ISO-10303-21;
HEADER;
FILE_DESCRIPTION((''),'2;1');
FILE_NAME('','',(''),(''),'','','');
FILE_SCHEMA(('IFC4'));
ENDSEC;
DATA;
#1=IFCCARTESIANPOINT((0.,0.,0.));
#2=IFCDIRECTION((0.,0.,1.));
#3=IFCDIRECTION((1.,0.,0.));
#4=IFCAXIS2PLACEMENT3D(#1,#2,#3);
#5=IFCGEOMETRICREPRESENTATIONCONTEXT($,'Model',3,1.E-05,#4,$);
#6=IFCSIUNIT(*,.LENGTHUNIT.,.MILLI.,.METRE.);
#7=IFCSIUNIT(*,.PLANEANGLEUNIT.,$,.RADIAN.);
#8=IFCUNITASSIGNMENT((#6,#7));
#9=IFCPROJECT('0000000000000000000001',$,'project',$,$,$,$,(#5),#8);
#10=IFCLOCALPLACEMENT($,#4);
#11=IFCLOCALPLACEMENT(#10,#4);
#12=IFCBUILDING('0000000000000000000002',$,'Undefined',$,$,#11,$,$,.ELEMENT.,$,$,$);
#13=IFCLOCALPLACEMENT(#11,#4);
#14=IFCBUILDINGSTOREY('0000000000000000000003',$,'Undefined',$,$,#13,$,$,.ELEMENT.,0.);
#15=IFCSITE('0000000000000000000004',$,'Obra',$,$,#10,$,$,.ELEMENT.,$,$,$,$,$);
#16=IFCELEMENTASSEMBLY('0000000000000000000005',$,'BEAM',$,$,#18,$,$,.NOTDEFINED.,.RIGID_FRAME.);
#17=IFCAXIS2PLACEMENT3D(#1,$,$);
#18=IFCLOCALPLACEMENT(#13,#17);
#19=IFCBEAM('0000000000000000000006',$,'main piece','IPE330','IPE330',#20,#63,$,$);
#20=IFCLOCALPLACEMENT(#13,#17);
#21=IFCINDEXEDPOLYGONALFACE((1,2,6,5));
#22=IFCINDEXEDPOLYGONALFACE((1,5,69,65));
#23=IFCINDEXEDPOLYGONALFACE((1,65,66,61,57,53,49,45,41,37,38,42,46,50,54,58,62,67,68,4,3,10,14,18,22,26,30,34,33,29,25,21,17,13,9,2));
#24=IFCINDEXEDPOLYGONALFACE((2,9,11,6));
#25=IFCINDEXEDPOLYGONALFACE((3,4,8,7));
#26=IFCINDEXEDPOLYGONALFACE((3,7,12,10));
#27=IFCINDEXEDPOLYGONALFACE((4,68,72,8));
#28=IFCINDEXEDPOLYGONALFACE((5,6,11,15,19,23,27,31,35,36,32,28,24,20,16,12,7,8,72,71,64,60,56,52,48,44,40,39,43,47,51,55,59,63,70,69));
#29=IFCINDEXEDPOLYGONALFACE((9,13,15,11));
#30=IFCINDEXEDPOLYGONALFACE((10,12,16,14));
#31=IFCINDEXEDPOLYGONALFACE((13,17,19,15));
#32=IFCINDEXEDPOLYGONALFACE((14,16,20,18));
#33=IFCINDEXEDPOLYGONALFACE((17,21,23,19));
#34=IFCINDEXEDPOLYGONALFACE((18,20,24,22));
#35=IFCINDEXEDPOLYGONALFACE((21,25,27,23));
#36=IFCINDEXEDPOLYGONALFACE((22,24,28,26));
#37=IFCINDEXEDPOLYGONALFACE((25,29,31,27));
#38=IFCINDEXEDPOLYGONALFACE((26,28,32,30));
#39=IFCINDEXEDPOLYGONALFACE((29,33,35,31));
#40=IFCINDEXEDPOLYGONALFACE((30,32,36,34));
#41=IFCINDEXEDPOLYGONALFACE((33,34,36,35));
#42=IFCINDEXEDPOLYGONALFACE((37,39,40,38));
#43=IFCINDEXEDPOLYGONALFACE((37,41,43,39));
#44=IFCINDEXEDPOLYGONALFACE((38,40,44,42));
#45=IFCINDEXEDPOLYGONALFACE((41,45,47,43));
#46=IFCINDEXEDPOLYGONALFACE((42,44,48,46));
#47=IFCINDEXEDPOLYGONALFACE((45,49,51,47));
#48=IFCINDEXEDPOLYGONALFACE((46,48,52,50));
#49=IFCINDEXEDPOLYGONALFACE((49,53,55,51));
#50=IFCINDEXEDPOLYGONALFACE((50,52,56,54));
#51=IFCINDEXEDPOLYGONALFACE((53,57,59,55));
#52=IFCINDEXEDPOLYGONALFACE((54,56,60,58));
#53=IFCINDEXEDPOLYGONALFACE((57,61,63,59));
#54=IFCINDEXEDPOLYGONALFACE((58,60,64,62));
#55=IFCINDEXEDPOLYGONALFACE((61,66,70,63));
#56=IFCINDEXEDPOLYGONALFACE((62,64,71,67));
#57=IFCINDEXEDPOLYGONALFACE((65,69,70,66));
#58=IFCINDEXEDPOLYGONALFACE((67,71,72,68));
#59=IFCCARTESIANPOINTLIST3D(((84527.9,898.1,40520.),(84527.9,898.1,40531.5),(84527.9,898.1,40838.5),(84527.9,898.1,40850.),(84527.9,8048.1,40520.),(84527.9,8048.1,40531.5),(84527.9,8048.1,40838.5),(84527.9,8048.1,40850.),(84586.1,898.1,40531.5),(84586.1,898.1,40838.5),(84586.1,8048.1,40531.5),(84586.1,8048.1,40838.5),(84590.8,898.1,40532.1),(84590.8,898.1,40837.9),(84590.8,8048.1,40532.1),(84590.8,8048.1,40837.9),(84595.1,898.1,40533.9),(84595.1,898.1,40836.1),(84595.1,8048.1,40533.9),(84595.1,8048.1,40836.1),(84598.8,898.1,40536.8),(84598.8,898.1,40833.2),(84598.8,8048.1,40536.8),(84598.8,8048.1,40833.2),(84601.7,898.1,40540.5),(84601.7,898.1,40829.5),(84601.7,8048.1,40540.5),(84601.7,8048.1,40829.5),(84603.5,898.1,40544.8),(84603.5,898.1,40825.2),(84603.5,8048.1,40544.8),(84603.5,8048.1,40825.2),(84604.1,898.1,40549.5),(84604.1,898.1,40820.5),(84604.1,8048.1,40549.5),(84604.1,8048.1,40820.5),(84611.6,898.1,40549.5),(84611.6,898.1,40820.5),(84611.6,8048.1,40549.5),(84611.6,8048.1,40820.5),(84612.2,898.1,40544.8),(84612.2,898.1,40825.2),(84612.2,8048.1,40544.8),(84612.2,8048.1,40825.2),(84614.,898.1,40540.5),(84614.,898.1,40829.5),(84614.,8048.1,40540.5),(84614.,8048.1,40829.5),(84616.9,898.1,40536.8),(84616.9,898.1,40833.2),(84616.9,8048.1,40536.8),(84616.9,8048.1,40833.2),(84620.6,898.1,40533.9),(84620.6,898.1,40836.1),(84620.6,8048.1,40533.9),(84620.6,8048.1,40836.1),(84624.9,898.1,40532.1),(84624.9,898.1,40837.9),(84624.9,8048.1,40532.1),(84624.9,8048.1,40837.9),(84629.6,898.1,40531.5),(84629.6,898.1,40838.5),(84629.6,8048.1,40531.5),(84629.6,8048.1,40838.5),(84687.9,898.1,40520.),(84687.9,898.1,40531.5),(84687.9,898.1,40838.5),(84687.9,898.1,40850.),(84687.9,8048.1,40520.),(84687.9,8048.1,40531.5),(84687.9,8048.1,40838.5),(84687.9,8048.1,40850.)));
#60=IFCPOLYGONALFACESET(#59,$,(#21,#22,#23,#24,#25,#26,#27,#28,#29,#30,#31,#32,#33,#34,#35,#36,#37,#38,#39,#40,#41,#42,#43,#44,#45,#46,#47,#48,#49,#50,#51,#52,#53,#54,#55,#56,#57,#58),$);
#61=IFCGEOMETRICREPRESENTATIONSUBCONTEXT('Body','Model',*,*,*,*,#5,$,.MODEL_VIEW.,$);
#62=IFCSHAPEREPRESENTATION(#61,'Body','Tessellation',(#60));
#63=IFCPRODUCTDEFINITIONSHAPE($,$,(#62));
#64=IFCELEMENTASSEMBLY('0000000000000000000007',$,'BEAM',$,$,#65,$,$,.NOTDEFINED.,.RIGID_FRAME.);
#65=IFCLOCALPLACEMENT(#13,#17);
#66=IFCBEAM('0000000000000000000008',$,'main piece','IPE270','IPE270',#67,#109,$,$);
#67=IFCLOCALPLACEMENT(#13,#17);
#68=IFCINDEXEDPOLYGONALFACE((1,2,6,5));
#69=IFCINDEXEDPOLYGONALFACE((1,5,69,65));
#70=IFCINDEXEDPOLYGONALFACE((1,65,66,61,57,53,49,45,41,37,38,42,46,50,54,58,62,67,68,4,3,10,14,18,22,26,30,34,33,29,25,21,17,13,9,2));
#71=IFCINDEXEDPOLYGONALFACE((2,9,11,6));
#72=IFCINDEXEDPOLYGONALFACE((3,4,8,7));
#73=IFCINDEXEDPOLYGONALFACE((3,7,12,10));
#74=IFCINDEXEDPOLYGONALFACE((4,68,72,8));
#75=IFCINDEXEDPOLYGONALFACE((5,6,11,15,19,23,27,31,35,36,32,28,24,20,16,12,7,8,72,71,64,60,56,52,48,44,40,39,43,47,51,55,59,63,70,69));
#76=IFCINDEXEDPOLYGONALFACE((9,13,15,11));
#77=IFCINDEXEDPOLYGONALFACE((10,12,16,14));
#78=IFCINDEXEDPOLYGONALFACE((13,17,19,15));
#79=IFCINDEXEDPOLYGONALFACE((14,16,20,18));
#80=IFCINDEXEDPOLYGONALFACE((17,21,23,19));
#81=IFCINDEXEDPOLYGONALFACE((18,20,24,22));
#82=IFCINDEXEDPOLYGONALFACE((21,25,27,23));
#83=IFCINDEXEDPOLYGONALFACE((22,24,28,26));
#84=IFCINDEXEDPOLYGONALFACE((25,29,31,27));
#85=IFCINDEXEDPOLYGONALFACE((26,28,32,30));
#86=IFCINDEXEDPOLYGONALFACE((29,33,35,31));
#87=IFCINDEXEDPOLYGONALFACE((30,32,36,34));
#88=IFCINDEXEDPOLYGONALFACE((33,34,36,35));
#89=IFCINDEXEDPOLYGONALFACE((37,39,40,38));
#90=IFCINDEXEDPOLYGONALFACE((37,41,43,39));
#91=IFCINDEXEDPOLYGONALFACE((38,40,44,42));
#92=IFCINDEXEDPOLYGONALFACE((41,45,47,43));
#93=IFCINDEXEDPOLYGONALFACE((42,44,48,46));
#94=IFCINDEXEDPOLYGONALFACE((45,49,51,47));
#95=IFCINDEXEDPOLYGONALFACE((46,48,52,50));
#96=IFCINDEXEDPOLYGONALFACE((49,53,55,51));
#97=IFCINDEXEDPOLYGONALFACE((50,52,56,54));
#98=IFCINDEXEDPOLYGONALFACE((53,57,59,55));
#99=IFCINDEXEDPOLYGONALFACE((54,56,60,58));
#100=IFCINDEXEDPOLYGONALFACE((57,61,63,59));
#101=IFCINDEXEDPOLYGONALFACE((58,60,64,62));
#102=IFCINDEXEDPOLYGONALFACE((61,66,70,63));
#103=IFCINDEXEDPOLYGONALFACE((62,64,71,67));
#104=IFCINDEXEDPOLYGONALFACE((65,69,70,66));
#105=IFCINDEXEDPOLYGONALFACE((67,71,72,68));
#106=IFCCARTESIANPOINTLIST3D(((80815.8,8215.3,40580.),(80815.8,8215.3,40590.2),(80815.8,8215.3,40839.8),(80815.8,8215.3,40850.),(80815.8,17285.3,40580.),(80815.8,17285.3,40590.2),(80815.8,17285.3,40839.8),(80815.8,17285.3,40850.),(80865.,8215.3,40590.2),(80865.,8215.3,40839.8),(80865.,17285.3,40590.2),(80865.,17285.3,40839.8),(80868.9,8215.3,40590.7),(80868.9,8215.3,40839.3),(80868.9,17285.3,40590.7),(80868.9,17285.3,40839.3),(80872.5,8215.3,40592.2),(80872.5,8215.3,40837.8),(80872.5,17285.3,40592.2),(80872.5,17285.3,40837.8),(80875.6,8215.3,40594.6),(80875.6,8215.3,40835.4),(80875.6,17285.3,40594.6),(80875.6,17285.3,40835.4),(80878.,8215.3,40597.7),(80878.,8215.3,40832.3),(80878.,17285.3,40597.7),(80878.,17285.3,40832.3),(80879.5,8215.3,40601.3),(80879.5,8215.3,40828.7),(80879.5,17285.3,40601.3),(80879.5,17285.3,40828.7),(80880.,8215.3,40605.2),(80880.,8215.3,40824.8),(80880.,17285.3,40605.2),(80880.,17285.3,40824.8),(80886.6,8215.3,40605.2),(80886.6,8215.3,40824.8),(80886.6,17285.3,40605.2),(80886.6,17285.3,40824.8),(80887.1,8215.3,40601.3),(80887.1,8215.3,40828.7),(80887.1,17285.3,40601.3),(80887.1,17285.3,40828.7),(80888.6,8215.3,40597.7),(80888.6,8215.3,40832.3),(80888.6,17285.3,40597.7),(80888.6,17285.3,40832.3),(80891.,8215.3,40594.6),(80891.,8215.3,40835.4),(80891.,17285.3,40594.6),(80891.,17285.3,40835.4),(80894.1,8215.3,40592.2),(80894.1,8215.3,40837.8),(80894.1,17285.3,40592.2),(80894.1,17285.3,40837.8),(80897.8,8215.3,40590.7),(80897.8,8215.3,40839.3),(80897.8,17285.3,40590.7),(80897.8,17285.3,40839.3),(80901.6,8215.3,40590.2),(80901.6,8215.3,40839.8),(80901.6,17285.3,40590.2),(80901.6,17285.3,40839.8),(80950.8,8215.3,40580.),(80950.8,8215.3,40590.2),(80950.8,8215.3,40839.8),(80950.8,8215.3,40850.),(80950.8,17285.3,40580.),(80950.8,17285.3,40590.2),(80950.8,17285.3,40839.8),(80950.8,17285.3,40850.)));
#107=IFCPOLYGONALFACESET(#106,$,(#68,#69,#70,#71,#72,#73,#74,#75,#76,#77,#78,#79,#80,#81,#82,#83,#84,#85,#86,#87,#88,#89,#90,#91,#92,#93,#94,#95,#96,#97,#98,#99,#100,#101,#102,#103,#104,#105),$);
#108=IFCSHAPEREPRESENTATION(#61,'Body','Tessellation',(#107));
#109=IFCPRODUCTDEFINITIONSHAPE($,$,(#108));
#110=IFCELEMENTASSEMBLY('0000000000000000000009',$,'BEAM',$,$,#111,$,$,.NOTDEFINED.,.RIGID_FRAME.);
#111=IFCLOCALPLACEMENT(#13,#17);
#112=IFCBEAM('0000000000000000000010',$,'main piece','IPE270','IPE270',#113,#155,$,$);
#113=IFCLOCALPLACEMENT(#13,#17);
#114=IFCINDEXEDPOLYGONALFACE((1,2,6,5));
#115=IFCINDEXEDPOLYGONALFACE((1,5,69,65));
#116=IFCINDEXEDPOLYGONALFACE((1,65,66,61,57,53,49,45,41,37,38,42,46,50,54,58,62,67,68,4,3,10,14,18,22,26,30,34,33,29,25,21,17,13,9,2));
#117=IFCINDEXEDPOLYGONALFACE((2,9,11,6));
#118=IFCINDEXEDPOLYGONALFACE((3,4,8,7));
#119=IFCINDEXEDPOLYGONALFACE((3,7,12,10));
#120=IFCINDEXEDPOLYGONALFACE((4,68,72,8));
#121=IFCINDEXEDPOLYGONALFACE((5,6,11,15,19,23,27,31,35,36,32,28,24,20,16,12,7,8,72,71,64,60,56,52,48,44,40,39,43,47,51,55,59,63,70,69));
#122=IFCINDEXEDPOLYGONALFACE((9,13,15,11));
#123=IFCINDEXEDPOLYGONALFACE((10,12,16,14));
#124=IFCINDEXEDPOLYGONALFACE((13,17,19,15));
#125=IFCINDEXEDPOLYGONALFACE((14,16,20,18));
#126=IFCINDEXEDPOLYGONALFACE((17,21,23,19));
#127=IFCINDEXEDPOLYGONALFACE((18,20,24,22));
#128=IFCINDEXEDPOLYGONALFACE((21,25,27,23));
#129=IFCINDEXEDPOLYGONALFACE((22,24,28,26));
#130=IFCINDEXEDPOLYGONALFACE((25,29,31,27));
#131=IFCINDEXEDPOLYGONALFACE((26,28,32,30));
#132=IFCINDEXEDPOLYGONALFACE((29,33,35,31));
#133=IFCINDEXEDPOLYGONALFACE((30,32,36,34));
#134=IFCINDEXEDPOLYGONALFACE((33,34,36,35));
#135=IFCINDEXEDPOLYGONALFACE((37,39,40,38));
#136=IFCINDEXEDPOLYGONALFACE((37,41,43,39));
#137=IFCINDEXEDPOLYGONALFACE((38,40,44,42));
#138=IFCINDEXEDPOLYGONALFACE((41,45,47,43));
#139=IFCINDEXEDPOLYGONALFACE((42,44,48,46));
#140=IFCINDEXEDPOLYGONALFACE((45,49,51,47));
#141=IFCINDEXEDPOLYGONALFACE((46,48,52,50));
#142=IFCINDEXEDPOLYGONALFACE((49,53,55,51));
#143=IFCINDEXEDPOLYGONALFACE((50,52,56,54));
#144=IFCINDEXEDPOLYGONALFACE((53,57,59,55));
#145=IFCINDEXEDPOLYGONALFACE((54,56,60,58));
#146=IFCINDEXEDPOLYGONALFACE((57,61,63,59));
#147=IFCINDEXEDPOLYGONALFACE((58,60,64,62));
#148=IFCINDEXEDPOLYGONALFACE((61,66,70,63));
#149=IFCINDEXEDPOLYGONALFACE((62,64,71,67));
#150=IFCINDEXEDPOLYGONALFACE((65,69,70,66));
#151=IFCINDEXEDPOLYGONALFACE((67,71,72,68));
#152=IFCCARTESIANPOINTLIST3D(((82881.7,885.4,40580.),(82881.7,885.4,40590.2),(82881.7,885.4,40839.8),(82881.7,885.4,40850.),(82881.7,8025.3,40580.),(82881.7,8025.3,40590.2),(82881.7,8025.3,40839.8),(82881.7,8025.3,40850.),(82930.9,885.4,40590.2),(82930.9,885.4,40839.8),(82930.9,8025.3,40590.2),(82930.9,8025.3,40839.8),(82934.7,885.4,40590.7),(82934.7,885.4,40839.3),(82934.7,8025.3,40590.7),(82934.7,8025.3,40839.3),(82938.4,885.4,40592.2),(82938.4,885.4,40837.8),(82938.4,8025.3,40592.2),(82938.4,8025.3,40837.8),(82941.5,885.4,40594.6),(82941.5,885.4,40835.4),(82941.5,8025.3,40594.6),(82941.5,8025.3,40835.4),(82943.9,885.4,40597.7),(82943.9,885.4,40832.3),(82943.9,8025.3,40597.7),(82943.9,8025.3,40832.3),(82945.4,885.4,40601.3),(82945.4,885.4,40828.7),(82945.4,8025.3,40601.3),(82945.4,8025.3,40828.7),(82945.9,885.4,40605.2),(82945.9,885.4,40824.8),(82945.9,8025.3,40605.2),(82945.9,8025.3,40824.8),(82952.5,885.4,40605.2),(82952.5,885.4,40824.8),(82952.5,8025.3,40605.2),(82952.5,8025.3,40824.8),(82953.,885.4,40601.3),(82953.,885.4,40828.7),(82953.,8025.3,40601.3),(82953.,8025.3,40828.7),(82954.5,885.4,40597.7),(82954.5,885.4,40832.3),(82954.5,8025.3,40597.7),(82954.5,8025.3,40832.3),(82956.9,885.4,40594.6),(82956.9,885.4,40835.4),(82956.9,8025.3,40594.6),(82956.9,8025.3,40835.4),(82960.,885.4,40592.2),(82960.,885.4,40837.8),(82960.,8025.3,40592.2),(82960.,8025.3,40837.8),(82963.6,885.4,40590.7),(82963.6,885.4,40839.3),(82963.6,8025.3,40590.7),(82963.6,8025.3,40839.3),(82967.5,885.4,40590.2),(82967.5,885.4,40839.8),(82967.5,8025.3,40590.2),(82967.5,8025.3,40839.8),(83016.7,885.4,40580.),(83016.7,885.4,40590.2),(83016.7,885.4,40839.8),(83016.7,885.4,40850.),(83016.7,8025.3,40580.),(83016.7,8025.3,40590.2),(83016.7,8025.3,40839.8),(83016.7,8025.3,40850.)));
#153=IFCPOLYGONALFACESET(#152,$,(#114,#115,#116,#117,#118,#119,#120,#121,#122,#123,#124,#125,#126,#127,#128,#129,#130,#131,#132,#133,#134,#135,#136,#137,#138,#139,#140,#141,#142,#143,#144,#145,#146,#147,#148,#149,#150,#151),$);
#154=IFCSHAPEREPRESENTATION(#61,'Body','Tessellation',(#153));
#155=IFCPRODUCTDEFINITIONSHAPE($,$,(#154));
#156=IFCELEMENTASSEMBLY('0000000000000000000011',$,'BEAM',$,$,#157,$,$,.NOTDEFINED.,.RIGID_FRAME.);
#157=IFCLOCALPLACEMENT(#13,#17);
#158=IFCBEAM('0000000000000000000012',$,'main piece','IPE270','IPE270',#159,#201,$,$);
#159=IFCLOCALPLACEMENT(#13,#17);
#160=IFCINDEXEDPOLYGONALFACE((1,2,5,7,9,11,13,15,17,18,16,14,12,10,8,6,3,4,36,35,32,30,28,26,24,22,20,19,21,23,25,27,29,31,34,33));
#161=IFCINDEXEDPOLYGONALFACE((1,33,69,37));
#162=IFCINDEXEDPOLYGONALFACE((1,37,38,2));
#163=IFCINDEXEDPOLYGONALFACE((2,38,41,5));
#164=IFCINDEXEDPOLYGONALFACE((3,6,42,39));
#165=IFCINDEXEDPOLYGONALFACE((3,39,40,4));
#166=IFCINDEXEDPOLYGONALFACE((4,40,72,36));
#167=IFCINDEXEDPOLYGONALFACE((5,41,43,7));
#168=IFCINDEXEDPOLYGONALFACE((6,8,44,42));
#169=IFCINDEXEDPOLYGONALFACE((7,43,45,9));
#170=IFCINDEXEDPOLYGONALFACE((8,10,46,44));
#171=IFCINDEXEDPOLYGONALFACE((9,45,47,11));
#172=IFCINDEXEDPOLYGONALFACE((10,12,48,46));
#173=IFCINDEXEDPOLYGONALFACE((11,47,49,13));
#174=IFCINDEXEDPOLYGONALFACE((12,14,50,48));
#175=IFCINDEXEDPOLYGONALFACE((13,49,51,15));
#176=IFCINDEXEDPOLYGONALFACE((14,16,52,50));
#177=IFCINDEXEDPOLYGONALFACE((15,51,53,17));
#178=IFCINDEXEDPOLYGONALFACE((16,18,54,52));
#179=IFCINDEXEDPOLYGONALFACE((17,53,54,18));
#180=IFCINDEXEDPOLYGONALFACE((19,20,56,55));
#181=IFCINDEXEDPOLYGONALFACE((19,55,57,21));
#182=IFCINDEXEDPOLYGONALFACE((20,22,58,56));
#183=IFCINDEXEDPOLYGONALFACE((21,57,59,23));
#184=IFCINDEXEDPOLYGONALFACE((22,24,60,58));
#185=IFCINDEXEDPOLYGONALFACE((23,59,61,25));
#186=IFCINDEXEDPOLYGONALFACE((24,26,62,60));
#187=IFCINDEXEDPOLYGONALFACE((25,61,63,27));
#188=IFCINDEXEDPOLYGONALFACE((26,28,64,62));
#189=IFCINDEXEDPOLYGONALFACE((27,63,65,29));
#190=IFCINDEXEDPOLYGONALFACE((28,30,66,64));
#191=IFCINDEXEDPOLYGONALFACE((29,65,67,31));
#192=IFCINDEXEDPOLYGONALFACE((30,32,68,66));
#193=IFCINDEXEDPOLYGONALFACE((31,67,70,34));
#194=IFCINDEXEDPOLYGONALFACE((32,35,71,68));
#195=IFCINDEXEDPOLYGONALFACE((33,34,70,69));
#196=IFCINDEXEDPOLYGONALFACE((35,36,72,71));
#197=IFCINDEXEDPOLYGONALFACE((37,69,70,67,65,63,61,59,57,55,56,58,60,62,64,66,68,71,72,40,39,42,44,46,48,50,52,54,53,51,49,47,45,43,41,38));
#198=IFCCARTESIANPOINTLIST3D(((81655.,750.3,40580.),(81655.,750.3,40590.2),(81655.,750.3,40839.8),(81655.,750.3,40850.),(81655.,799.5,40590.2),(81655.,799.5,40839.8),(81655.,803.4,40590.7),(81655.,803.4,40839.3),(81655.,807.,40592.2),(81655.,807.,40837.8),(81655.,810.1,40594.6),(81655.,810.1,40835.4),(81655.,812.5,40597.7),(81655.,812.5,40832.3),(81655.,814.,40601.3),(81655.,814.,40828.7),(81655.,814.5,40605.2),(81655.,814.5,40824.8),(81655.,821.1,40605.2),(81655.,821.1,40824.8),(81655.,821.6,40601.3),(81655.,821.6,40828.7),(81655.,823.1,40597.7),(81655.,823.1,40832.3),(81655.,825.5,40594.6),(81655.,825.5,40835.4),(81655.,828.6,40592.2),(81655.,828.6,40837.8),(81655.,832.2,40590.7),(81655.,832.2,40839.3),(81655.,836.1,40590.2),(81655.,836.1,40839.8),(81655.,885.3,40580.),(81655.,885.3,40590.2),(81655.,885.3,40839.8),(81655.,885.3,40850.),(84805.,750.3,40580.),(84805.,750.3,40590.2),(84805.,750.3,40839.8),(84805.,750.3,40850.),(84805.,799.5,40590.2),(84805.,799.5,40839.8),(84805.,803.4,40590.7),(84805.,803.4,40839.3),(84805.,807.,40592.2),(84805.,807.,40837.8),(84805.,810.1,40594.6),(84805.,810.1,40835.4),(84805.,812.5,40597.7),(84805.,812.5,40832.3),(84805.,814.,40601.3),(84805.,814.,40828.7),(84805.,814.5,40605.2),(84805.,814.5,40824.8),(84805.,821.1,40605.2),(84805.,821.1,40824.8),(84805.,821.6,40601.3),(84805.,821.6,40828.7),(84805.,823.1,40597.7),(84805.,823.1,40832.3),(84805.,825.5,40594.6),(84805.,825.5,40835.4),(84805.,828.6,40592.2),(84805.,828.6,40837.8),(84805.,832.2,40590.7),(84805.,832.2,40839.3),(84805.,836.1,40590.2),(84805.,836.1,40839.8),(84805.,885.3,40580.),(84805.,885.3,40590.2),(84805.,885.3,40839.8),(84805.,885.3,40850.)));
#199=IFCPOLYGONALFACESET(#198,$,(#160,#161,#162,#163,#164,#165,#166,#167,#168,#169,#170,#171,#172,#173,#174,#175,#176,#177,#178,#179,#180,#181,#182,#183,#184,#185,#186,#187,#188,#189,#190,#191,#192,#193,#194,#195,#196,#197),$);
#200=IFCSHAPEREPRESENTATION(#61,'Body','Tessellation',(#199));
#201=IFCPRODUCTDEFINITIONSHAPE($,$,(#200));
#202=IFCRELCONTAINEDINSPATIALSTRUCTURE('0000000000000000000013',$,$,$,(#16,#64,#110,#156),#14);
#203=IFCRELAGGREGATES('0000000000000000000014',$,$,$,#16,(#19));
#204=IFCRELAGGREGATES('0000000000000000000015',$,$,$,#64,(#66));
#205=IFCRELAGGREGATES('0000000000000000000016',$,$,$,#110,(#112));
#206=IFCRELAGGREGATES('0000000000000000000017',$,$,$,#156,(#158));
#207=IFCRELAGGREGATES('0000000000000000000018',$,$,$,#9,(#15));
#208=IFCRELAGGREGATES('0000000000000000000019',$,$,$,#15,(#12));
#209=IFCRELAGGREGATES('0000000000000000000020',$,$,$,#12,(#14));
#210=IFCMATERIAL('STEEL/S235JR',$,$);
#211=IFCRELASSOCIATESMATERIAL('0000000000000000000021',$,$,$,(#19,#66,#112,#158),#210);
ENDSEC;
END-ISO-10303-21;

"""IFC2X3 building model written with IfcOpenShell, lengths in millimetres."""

from ifc_helpers import new_model, si_unit, frame, origin_with_axes, origin_2d_with_axis, place, context, subcontext, project, spatial, i_section, extrude, material, element, aggregate, save


model = new_model("IFC2X3")

# Units and contexts
model_context = context("Model", 3, precision=1e-05, world=origin_with_axes())
body_context = subcontext(model_context, "Body", "Model", "MODEL_VIEW")
ifc_project = project(units=[si_unit("LENGTHUNIT", "METRE", prefix="MILLI"), si_unit("PLANEANGLEUNIT", "RADIAN")], contexts=[model_context])

# Site, building, storey
site_placement = place(None, origin_with_axes())
site = spatial("IfcSite", under=ifc_project, at=site_placement, Name="Obra", CompositionType="ELEMENT")
building_placement = place(site_placement, origin_with_axes())
building = spatial("IfcBuilding", under=site, at=building_placement, Name="Undefined", CompositionType="ELEMENT")
storey_placement = place(building_placement, origin_with_axes())
storey = spatial("IfcBuildingStorey", under=building, at=storey_placement, Name="Undefined", CompositionType="ELEMENT", Elevation=0.0)

# Shared definitions
ifc_material_1 = material(Name="STEEL/S235JR")

# Element assemblies, beams
assembly_1_placement = place(storey_placement, origin_with_axes())
assembly_1 = element("IfcElementAssembly", 1, at=assembly_1_placement, inside=storey, Name="BEAM", AssemblyPlace="NOTDEFINED", PredefinedType="RIGID_FRAME")
beam_1_placement = place(assembly_1_placement, frame((84607.9, 898.1, 40685.0), z_axis=(0.0, 0.0, 1.0), x_axis=(0.0, 1.0, 0.0)))
beam_1 = element("IfcBeam", 2, at=beam_1_placement, material=ifc_material_1, Name="main piece", Description="IPE330", ObjectType="IPE330", context=body_context, shape_type="SweptSolid", body=[
    extrude(i_section(OverallWidth=160.0, OverallDepth=330.0, WebThickness=7.5, FlangeThickness=11.5, FilletRadius=18.0, at=origin_2d_with_axis()), frame((7150.0, 0.0, 0.0), z_axis=(-1.0, 0.0, 0.0), x_axis=(0.0, -1.0, 0.0)), (0.0, 0.0, 1.0), 7150.0),
])
aggregate(assembly_1, [beam_1])
assembly_2_placement = place(storey_placement, origin_with_axes())
assembly_2 = element("IfcElementAssembly", 3, at=assembly_2_placement, inside=storey, Name="BEAM", AssemblyPlace="NOTDEFINED", PredefinedType="RIGID_FRAME")
beam_2_placement = place(assembly_2_placement, frame((80883.3, 8215.3, 40715.0), z_axis=(0.0, 0.0, 1.0), x_axis=(0.0, 1.0, 0.0)))
beam_2 = element("IfcBeam", 4, at=beam_2_placement, material=ifc_material_1, Name="main piece", Description="IPE270", ObjectType="IPE270", context=body_context, shape_type="SweptSolid", body=[
    extrude(i_section(OverallWidth=135.0, OverallDepth=270.0, WebThickness=6.6, FlangeThickness=10.2, FilletRadius=15.0, at=origin_2d_with_axis()), frame((9070.0, 0.0, 0.0), z_axis=(-1.0, 0.0, 0.0), x_axis=(0.0, -1.0, 0.0)), (0.0, 0.0, 1.0), 9070.0),
])
aggregate(assembly_2, [beam_2])
assembly_3_placement = place(storey_placement, origin_with_axes())
assembly_3 = element("IfcElementAssembly", 5, at=assembly_3_placement, inside=storey, Name="BEAM", AssemblyPlace="NOTDEFINED", PredefinedType="RIGID_FRAME")
beam_3_placement = place(assembly_3_placement, frame((82949.2, 885.4, 40715.0), z_axis=(0.0, 0.0, 1.0), x_axis=(0.0, 1.0, 0.0)))
beam_3 = element("IfcBeam", 6, at=beam_3_placement, material=ifc_material_1, Name="main piece", Description="IPE270", ObjectType="IPE270", context=body_context, shape_type="SweptSolid", body=[
    extrude(i_section(OverallWidth=135.0, OverallDepth=270.0, WebThickness=6.6, FlangeThickness=10.2, FilletRadius=15.0, at=origin_2d_with_axis()), frame((7139.9, 0.0, 0.0), z_axis=(-1.0, 0.0, 0.0), x_axis=(0.0, -1.0, 0.0)), (0.0, 0.0, 1.0), 7139.9),
])
aggregate(assembly_3, [beam_3])
assembly_4_placement = place(storey_placement, origin_with_axes())
assembly_4 = element("IfcElementAssembly", 7, at=assembly_4_placement, inside=storey, Name="BEAM", AssemblyPlace="NOTDEFINED", PredefinedType="RIGID_FRAME")
beam_4_placement = place(assembly_4_placement, frame((81655.0, 817.8, 40715.0), z_axis=(0.0, 0.0, 1.0), x_axis=(1.0, 0.0, 0.0)))
beam_4 = element("IfcBeam", 8, at=beam_4_placement, material=ifc_material_1, Name="main piece", Description="IPE270", ObjectType="IPE270", context=body_context, shape_type="SweptSolid", body=[
    extrude(i_section(OverallWidth=135.0, OverallDepth=270.0, WebThickness=6.6, FlangeThickness=10.2, FilletRadius=15.0, at=origin_2d_with_axis()), frame((3150.0, 0.0, 0.0), z_axis=(-1.0, 0.0, 0.0), x_axis=(0.0, -1.0, 0.0)), (0.0, 0.0, 1.0), 3150.0),
])
aggregate(assembly_4, [beam_4])

save(model, "model.ifc")
